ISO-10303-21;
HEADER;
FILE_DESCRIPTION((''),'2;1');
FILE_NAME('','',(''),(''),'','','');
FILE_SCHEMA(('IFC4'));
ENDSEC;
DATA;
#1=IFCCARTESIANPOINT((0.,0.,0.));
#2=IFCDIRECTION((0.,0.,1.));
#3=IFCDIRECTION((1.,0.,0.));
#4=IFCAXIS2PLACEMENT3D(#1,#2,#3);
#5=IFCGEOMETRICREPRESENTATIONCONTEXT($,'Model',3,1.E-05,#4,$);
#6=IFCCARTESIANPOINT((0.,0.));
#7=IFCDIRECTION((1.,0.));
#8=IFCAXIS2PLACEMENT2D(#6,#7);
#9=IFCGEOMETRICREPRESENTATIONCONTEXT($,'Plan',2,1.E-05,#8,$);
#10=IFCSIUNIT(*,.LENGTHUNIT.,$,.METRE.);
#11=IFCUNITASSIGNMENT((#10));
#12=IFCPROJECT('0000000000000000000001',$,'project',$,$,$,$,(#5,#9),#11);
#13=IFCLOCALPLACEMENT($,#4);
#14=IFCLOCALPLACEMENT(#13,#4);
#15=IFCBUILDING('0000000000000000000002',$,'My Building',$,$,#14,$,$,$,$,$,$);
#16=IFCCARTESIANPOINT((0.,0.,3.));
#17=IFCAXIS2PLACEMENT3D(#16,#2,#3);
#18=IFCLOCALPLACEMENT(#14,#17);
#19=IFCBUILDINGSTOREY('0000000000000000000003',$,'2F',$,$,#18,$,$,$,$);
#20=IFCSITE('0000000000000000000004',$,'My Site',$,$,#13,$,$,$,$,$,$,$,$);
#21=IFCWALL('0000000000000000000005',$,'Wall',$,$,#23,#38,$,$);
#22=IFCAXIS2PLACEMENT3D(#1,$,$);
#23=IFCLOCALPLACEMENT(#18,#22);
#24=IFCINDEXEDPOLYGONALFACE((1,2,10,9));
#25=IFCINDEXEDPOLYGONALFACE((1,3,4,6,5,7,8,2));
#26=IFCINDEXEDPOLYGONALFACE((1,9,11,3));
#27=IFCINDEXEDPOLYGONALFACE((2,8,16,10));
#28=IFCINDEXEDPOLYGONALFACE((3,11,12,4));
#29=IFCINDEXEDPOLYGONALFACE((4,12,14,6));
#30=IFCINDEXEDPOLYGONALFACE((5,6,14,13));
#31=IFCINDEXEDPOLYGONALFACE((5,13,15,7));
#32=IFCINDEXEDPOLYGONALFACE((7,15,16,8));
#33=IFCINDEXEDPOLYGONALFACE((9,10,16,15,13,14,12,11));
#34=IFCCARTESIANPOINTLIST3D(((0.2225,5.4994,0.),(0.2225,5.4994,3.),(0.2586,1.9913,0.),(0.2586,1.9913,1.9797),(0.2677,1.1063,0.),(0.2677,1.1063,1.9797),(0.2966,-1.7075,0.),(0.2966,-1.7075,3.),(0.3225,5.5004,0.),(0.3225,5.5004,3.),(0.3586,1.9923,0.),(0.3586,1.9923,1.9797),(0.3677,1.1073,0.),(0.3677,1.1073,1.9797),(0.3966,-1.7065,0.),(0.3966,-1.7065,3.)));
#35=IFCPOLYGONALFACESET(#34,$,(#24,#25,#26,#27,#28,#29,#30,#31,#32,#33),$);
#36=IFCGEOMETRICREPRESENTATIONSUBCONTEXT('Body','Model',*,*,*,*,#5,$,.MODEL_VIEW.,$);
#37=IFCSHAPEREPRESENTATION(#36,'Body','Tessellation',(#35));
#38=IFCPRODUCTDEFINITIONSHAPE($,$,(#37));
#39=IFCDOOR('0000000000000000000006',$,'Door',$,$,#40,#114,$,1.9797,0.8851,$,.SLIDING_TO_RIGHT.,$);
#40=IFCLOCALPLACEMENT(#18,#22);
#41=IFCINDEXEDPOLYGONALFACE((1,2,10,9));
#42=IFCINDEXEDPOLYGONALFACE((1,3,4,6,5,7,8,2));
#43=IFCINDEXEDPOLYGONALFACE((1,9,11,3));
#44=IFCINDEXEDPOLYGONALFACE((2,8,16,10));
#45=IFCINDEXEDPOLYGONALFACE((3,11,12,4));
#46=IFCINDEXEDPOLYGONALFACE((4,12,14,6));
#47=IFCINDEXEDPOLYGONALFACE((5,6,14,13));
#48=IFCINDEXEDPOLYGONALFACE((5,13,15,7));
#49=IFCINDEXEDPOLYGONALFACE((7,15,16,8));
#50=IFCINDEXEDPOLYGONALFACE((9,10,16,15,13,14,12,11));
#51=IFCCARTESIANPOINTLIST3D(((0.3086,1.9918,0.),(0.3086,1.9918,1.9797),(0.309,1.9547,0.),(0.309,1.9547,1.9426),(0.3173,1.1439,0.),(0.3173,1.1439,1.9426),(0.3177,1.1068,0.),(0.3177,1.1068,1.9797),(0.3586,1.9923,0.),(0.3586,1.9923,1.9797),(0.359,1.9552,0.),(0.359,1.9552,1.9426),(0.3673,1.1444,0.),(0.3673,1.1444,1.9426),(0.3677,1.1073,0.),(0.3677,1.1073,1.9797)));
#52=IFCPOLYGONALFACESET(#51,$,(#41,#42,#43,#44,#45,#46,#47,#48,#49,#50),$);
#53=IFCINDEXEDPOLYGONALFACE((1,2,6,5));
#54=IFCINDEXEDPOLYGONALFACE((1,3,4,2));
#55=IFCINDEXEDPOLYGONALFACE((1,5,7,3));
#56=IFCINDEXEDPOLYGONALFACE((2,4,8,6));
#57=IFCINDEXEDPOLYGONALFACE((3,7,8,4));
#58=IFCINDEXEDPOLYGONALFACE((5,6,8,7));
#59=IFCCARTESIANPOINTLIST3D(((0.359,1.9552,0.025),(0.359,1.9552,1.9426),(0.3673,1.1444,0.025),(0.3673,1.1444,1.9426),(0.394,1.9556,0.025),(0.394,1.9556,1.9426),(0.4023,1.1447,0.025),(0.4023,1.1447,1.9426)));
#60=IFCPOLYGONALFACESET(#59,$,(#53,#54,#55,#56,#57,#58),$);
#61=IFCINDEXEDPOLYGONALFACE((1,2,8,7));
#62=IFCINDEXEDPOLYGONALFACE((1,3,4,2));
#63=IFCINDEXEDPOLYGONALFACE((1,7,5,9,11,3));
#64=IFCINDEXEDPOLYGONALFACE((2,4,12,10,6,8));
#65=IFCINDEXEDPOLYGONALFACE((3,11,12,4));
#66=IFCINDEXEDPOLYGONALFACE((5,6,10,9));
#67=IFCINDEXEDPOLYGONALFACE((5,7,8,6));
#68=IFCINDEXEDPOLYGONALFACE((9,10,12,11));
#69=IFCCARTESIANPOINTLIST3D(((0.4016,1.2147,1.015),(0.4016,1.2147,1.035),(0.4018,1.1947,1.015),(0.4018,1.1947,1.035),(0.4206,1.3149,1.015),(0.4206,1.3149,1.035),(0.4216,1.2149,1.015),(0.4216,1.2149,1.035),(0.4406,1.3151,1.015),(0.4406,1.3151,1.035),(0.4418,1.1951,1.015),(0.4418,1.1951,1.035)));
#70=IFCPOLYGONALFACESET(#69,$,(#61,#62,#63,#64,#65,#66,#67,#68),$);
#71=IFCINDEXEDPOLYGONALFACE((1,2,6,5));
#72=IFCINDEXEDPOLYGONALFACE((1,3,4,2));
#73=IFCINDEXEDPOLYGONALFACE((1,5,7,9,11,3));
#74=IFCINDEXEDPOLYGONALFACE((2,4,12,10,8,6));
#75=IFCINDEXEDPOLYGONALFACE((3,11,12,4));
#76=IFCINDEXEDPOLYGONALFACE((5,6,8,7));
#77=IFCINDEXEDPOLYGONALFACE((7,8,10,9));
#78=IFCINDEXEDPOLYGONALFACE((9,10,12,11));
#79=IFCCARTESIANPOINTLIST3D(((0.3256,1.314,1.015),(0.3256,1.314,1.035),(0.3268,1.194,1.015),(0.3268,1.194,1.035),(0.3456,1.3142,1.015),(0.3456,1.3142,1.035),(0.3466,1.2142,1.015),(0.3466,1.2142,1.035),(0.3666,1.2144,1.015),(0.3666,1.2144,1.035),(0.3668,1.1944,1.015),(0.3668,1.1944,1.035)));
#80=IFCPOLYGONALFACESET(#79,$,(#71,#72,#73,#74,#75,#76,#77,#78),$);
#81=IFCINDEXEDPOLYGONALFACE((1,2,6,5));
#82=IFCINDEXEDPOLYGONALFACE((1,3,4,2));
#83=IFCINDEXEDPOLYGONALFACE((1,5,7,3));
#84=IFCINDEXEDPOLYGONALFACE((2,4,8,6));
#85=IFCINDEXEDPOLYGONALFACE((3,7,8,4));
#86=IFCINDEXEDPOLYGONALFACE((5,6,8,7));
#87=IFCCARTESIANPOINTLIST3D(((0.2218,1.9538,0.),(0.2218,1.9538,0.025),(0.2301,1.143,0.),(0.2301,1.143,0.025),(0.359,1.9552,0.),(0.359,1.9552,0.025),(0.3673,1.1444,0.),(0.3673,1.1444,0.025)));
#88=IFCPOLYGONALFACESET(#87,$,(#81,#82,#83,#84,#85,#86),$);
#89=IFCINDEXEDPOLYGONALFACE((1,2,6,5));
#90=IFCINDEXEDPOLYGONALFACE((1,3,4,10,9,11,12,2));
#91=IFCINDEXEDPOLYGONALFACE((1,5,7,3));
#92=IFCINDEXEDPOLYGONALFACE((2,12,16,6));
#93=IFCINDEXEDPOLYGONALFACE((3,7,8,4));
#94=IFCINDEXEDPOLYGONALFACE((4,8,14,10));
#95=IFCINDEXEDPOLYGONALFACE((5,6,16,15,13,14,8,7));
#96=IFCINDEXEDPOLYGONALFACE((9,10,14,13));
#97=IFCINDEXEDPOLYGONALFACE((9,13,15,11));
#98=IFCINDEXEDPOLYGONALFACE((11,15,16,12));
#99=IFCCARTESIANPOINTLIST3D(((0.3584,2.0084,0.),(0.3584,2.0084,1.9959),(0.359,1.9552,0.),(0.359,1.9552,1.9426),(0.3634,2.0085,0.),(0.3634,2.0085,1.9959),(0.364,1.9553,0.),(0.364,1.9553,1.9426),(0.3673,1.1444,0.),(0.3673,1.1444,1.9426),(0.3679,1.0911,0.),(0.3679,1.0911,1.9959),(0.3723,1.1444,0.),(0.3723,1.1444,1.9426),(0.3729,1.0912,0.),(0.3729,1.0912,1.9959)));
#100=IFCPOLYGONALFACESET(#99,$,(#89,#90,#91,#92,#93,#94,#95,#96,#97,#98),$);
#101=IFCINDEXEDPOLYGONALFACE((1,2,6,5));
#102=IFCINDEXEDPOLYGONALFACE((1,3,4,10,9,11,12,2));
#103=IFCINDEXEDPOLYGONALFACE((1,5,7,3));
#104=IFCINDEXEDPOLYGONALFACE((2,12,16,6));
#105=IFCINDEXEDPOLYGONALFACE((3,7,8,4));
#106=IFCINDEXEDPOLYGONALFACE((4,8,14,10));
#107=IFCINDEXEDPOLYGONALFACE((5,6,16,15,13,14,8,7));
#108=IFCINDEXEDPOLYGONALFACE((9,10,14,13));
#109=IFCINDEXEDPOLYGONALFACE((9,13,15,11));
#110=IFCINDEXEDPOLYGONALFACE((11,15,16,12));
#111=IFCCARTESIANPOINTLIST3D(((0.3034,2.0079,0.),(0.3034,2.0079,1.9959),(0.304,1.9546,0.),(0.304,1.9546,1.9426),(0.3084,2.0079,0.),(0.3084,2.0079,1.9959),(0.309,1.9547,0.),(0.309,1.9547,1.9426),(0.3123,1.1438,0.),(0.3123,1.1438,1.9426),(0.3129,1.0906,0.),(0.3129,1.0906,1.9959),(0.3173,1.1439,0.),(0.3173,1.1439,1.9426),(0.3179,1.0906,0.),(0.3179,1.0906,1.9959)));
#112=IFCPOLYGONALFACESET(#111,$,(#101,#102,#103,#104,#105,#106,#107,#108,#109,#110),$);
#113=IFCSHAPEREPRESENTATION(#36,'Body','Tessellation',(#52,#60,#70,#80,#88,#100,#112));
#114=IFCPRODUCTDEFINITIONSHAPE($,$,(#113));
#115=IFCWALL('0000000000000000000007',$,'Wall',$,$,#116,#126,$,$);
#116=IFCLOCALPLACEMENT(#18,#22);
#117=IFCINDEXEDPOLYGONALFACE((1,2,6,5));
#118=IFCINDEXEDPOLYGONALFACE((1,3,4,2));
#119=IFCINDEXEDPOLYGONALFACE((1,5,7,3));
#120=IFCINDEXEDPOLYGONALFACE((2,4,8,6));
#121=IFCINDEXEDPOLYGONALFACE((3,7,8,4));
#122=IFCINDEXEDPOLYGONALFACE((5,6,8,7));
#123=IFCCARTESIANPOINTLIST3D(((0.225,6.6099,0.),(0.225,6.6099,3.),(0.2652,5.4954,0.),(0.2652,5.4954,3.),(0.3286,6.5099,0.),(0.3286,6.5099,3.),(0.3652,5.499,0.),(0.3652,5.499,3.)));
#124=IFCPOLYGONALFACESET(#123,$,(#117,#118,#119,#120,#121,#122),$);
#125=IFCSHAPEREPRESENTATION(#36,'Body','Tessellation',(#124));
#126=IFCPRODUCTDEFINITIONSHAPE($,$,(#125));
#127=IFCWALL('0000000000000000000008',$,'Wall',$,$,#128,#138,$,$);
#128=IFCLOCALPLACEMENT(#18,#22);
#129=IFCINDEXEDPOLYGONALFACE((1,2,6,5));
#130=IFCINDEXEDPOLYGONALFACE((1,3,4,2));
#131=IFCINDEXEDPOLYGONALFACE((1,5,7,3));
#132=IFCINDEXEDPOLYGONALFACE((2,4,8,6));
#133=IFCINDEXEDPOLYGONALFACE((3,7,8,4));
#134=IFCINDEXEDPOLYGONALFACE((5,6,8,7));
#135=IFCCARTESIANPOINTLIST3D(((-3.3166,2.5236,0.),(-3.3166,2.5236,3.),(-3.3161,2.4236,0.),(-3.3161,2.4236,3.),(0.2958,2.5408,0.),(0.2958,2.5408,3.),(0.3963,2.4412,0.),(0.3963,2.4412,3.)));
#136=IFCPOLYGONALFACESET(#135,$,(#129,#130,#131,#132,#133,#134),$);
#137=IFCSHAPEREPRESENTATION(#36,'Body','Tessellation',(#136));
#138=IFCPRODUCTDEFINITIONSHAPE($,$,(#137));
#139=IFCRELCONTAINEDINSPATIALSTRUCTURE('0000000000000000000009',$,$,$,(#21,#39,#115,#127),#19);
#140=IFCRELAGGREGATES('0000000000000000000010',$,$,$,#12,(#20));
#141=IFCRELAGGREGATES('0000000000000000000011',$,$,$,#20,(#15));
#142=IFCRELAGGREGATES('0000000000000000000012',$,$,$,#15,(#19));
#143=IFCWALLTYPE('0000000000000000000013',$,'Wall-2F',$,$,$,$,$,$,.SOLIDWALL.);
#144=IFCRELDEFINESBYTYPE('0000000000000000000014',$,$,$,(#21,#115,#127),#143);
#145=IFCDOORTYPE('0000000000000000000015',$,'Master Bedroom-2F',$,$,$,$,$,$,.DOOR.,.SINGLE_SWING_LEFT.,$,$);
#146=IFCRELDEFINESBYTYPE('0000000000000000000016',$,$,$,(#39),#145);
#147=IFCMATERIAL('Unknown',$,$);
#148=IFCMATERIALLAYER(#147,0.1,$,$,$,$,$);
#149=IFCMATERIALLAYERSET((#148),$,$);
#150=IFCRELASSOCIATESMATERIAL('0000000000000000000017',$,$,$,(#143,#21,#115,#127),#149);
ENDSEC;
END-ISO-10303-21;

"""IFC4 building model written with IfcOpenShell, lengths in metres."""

from ifc_helpers import new_model, entity, si_unit, frame, origin_with_axes, origin_2d_with_axis, place, context, subcontext, project, spatial, line, indexed_curve, outline, extrude, shape, source, transform, mapped, material, layer, layer_set, layer_usage, type_object, type_shapes, element, fill, save


model = new_model("IFC4")

# Units and contexts
model_context = context("Model", 3, precision=1e-05, world=origin_with_axes())
plan_context = context("Plan", 2, precision=1e-05, world=origin_2d_with_axis())
body_context_1 = subcontext(model_context, "Body", "Model", "MODEL_VIEW")
body_context_2 = subcontext(plan_context, "Body", "Plan", "PLAN_VIEW")
ifc_project = project(units=[si_unit("LENGTHUNIT", "METRE")], contexts=[model_context, plan_context])

# Site, building, storey
site_placement = place(None, origin_with_axes())
site = spatial("IfcSite", under=ifc_project, at=site_placement, Name="My Site")
building_placement = place(site_placement, origin_with_axes())
building = spatial("IfcBuilding", under=site, at=building_placement, Name="My Building")
storey_placement = place(building_placement, frame((0.0, 0.0, 3.0), z_axis=(0.0, 0.0, 1.0), x_axis=(1.0, 0.0, 0.0)))
storey = spatial("IfcBuildingStorey", under=building, at=storey_placement, Name="2F")

# Shared definitions
ifc_material = material(Name="Unknown")

# Shared definitions
ifc_layer_1 = layer(ifc_material, 0.1)
ifc_layer_set_1 = layer_set([ifc_layer_1])
wall_type = type_object("IfcWallType", Name="Wall-2F", PredefinedType="SOLIDWALL", material=ifc_layer_set_1)

# Wall, opening, door
ifc_layer_usage_1 = layer_usage(ifc_layer_set_1, "AXIS2", "POSITIVE", 0.0)
wall_1_placement = place(storey_placement, frame((0.2225, 5.4994, 0.0), z_axis=(0.0, 0.0, 1.0), x_axis=(0.010284, -0.999947, 0.0)))
wall_1 = element("IfcWall", 1, at=wall_1_placement, inside=storey, type_object=wall_type, material=ifc_layer_usage_1, Name="Wall", context=body_context_1, shape_type="SweptSolid", body=[
    extrude(outline(indexed_curve([(0.0, 0.0), (0.0, 0.1), (7.2073, 0.1), (7.2073, 0.0)], segments=[line(1, 2, 3, 4, 1)])), origin_with_axes(), (0.0, 0.0, 1.0), 3.0),
])
shared_shape_1 = source(origin_with_axes(), body_context_1, "Body", "SweptSolid", [
    extrude(outline(indexed_curve([(0.0, 0.0), (0.8851, 0.0), (0.8851, 1.9797), (0.0, 1.9797)], segments=[line(1, 2, 3, 4, 1)])), frame((0.0, -0.6, 0.0), z_axis=(0.0, -1.0, 0.0), x_axis=(1.0, 0.0, 0.0)), (0.0, 0.0, -1.0), 1.2),
])
opening_1_placement = place(wall_1_placement, frame((4.3934, 0.1, 0.0), z_axis=(0.0, 0.0, 1.0), x_axis=(-1.0, 0.0, 0.0)))
opening_1 = element("IfcOpeningElement", 2, at=opening_1_placement, cuts=wall_1, PredefinedType="OPENING", context=body_context_1, shape_type="MappedRepresentation", body=[
    mapped(shared_shape_1, transform((0.0, 0.0, 0.0), x_axis=(1.0, 0.0, 0.0), y_axis=(0.0, 1.0, 0.0), z_axis=(0.0, 0.0, 1.0), scale=1.0)),
])
door_type_1 = type_object("IfcDoorType", Name="Master Bedroom-2F", OperationType="SINGLE_SWING_LEFT", PredefinedType="DOOR")
shared_shape_2 = source(origin_with_axes(), body_context_1, "Body", "SweptSolid", [
    extrude(outline(indexed_curve([(0.0, 0.0), (0.0, 1.9797), (0.8851, 1.9797), (0.8851, 0.0), (0.848, 0.0), (0.848, 1.9426), (0.0371, 1.9426), (0.0371, 0.0)], segments=[line(1, 2, 3, 4, 5, 6, 7, 8, 1)])), frame((0.0, 0.0, 0.0), z_axis=(0.0, -1.0, 0.0), x_axis=(1.0, 0.0, 0.0)), (0.0, 0.0, -1.0), 0.05),
    extrude(outline(indexed_curve([(0.0, 0.0), (0.8109, 0.0), (0.8109, 0.035), (0.0, 0.035)], segments=[line(1, 2, 3, 4, 1)])), frame((0.0371, -0.035, 0.025), z_axis=(0.0, 0.0, 1.0), x_axis=(1.0, 0.0, 0.0)), (0.0, 0.0, 1.0), 1.9176),
    extrude(outline(indexed_curve([(0.0, 0.0), (0.0, -0.04), (0.12, -0.04), (0.12, -0.02), (0.02, -0.02), (0.02, 0.0)], segments=[line(1, 2, 3, 4, 5, 6, 1)])), frame((0.0871, -0.035, 1.015), z_axis=(0.0, 0.0, 1.0), x_axis=(1.0, 0.0, 0.0)), (0.0, 0.0, 1.0), 0.02),
    extrude(outline(indexed_curve([(0.0, 0.0), (0.0, 0.04), (0.12, 0.04), (0.12, 0.02), (0.02, 0.02), (0.02, 0.0)], segments=[line(1, 2, 3, 4, 5, 6, 1)])), frame((0.0871, 0.0, 1.015), z_axis=(0.0, 0.0, 1.0), x_axis=(1.0, 0.0, 0.0)), (0.0, 0.0, 1.0), 0.02),
    extrude(outline(indexed_curve([(0.0, 0.0), (0.8109, 0.0), (0.8109, 0.1372), (0.0, 0.1372)], segments=[line(1, 2, 3, 4, 1)])), frame((0.0371, 0.0, 0.0), z_axis=(0.0, 0.0, 1.0), x_axis=(1.0, 0.0, 0.0)), (0.0, 0.0, 1.0), 0.025),
    extrude(outline(indexed_curve([(0.0, 0.0), (0.0, 1.9959), (0.9174, 1.9959), (0.9174, 0.0), (0.8641, 0.0), (0.8641, 1.9426), (0.0532, 1.9426), (0.0532, 0.0)], segments=[line(1, 2, 3, 4, 5, 6, 7, 8, 1)])), frame((-0.0162, -0.005, 0.0), z_axis=(0.0, -1.0, 0.0), x_axis=(1.0, 0.0, 0.0)), (0.0, 0.0, -1.0), 0.005),
    extrude(outline(indexed_curve([(0.0, 0.0), (0.0, 1.9959), (0.9174, 1.9959), (0.9174, 0.0), (0.8641, 0.0), (0.8641, 1.9426), (0.0532, 1.9426), (0.0532, 0.0)], segments=[line(1, 2, 3, 4, 5, 6, 7, 8, 1)])), frame((-0.0162, 0.05, 0.0), z_axis=(0.0, -1.0, 0.0), x_axis=(1.0, 0.0, 0.0)), (0.0, 0.0, -1.0), 0.005),
])
shared_shape_3 = source(origin_with_axes(), body_context_2, "Body", "Curve2D", [
    entity("IfcIndexedPolyCurve", entity("IfcCartesianPointList2D", [[0.0, 0.0], [0.0371, 0.0], [0.0371, 0.05], [0.0, 0.05]]), [entity("IfcLineIndex", [1, 2, 3, 4, 1])]),
    entity("IfcIndexedPolyCurve", entity("IfcCartesianPointList2D", [[0.8851, 0.0], [0.848, 0.0], [0.848, 0.05], [0.8851, 0.05]]), [entity("IfcLineIndex", [1, 2, 3, 4, 1])]),
    entity("IfcIndexedPolyCurve", entity("IfcCartesianPointList2D", [[1.2534, -0.035], [0.4425, -0.035], [0.4425, 0.0], [1.2534, 0.0]]), [entity("IfcLineIndex", [1, 2, 3, 4, 1])]),
])
type_shapes(door_type_1, [shared_shape_2, shared_shape_3])
door_1_placement = place(opening_1_placement, frame((0.0, 0.0, 0.0), z_axis=(0.0, 0.0, 1.0), x_axis=(1.0, 0.0, 0.0)))
door_1 = element("IfcDoor", 3, at=door_1_placement, inside=storey, type_object=door_type_1, Name="Door", OperationType="SLIDING_TO_RIGHT", OverallHeight=1.9797, OverallWidth=0.8851, shapes=[
    shape(body_context_1, "Body", "MappedRepresentation", [mapped(shared_shape_2, transform((0.0, 0.0, 0.0), x_axis=(1.0, 0.0, 0.0), y_axis=(0.0, 1.0, 0.0), z_axis=(0.0, 0.0, 1.0), scale=1.0))]),
    shape(body_context_2, "Body", "MappedRepresentation", [mapped(shared_shape_3, transform((0.0, 0.0, 0.0), x_axis=(1.0, 0.0, 0.0), y_axis=(0.0, 1.0, 0.0), z_axis=(0.0, 0.0, 1.0), scale=1.0))]),
])
fill(opening_1, door_1)

# Wall
ifc_layer_usage_2 = layer_usage(ifc_layer_set_1, "AXIS2", "POSITIVE", 0.0)
wall_2_placement = place(storey_placement, frame((0.3652, 5.499, 0.0), z_axis=(0.0, 0.0, 1.0), x_axis=(-0.0361, 0.999348, 0.0)))
element("IfcWall", 4, at=wall_2_placement, inside=storey, type_object=wall_type, material=ifc_layer_usage_2, Name="Wall", context=body_context_1, shape_type="SweptSolid", body=[
    extrude(outline(indexed_curve([(0.0, 0.0), (0.0, 0.1), (1.1153, 0.1), (1.0116, 0.0)], segments=[line(1, 2, 3, 4, 1)])), origin_with_axes(), (0.0, 0.0, 1.0), 3.0),
])

# Wall
ifc_layer_usage_3 = layer_usage(ifc_layer_set_1, "AXIS2", "POSITIVE", 0.0)
wall_3_placement = place(storey_placement, frame((0.2958, 2.5408, 0.0), z_axis=(0.0, 0.0, 1.0), x_axis=(-0.999989, -0.004745, 0.0)))
element("IfcWall", 5, at=wall_3_placement, inside=storey, type_object=wall_type, material=ifc_layer_usage_3, Name="Wall", context=body_context_1, shape_type="SweptSolid", body=[
    extrude(outline(indexed_curve([(0.0, 0.0), (-0.1, 0.1), (3.6124, 0.1), (3.6124, 0.0)], segments=[line(1, 2, 3, 4, 1)])), origin_with_axes(), (0.0, 0.0, 1.0), 3.0),
])

save(model, "model.ifc")
